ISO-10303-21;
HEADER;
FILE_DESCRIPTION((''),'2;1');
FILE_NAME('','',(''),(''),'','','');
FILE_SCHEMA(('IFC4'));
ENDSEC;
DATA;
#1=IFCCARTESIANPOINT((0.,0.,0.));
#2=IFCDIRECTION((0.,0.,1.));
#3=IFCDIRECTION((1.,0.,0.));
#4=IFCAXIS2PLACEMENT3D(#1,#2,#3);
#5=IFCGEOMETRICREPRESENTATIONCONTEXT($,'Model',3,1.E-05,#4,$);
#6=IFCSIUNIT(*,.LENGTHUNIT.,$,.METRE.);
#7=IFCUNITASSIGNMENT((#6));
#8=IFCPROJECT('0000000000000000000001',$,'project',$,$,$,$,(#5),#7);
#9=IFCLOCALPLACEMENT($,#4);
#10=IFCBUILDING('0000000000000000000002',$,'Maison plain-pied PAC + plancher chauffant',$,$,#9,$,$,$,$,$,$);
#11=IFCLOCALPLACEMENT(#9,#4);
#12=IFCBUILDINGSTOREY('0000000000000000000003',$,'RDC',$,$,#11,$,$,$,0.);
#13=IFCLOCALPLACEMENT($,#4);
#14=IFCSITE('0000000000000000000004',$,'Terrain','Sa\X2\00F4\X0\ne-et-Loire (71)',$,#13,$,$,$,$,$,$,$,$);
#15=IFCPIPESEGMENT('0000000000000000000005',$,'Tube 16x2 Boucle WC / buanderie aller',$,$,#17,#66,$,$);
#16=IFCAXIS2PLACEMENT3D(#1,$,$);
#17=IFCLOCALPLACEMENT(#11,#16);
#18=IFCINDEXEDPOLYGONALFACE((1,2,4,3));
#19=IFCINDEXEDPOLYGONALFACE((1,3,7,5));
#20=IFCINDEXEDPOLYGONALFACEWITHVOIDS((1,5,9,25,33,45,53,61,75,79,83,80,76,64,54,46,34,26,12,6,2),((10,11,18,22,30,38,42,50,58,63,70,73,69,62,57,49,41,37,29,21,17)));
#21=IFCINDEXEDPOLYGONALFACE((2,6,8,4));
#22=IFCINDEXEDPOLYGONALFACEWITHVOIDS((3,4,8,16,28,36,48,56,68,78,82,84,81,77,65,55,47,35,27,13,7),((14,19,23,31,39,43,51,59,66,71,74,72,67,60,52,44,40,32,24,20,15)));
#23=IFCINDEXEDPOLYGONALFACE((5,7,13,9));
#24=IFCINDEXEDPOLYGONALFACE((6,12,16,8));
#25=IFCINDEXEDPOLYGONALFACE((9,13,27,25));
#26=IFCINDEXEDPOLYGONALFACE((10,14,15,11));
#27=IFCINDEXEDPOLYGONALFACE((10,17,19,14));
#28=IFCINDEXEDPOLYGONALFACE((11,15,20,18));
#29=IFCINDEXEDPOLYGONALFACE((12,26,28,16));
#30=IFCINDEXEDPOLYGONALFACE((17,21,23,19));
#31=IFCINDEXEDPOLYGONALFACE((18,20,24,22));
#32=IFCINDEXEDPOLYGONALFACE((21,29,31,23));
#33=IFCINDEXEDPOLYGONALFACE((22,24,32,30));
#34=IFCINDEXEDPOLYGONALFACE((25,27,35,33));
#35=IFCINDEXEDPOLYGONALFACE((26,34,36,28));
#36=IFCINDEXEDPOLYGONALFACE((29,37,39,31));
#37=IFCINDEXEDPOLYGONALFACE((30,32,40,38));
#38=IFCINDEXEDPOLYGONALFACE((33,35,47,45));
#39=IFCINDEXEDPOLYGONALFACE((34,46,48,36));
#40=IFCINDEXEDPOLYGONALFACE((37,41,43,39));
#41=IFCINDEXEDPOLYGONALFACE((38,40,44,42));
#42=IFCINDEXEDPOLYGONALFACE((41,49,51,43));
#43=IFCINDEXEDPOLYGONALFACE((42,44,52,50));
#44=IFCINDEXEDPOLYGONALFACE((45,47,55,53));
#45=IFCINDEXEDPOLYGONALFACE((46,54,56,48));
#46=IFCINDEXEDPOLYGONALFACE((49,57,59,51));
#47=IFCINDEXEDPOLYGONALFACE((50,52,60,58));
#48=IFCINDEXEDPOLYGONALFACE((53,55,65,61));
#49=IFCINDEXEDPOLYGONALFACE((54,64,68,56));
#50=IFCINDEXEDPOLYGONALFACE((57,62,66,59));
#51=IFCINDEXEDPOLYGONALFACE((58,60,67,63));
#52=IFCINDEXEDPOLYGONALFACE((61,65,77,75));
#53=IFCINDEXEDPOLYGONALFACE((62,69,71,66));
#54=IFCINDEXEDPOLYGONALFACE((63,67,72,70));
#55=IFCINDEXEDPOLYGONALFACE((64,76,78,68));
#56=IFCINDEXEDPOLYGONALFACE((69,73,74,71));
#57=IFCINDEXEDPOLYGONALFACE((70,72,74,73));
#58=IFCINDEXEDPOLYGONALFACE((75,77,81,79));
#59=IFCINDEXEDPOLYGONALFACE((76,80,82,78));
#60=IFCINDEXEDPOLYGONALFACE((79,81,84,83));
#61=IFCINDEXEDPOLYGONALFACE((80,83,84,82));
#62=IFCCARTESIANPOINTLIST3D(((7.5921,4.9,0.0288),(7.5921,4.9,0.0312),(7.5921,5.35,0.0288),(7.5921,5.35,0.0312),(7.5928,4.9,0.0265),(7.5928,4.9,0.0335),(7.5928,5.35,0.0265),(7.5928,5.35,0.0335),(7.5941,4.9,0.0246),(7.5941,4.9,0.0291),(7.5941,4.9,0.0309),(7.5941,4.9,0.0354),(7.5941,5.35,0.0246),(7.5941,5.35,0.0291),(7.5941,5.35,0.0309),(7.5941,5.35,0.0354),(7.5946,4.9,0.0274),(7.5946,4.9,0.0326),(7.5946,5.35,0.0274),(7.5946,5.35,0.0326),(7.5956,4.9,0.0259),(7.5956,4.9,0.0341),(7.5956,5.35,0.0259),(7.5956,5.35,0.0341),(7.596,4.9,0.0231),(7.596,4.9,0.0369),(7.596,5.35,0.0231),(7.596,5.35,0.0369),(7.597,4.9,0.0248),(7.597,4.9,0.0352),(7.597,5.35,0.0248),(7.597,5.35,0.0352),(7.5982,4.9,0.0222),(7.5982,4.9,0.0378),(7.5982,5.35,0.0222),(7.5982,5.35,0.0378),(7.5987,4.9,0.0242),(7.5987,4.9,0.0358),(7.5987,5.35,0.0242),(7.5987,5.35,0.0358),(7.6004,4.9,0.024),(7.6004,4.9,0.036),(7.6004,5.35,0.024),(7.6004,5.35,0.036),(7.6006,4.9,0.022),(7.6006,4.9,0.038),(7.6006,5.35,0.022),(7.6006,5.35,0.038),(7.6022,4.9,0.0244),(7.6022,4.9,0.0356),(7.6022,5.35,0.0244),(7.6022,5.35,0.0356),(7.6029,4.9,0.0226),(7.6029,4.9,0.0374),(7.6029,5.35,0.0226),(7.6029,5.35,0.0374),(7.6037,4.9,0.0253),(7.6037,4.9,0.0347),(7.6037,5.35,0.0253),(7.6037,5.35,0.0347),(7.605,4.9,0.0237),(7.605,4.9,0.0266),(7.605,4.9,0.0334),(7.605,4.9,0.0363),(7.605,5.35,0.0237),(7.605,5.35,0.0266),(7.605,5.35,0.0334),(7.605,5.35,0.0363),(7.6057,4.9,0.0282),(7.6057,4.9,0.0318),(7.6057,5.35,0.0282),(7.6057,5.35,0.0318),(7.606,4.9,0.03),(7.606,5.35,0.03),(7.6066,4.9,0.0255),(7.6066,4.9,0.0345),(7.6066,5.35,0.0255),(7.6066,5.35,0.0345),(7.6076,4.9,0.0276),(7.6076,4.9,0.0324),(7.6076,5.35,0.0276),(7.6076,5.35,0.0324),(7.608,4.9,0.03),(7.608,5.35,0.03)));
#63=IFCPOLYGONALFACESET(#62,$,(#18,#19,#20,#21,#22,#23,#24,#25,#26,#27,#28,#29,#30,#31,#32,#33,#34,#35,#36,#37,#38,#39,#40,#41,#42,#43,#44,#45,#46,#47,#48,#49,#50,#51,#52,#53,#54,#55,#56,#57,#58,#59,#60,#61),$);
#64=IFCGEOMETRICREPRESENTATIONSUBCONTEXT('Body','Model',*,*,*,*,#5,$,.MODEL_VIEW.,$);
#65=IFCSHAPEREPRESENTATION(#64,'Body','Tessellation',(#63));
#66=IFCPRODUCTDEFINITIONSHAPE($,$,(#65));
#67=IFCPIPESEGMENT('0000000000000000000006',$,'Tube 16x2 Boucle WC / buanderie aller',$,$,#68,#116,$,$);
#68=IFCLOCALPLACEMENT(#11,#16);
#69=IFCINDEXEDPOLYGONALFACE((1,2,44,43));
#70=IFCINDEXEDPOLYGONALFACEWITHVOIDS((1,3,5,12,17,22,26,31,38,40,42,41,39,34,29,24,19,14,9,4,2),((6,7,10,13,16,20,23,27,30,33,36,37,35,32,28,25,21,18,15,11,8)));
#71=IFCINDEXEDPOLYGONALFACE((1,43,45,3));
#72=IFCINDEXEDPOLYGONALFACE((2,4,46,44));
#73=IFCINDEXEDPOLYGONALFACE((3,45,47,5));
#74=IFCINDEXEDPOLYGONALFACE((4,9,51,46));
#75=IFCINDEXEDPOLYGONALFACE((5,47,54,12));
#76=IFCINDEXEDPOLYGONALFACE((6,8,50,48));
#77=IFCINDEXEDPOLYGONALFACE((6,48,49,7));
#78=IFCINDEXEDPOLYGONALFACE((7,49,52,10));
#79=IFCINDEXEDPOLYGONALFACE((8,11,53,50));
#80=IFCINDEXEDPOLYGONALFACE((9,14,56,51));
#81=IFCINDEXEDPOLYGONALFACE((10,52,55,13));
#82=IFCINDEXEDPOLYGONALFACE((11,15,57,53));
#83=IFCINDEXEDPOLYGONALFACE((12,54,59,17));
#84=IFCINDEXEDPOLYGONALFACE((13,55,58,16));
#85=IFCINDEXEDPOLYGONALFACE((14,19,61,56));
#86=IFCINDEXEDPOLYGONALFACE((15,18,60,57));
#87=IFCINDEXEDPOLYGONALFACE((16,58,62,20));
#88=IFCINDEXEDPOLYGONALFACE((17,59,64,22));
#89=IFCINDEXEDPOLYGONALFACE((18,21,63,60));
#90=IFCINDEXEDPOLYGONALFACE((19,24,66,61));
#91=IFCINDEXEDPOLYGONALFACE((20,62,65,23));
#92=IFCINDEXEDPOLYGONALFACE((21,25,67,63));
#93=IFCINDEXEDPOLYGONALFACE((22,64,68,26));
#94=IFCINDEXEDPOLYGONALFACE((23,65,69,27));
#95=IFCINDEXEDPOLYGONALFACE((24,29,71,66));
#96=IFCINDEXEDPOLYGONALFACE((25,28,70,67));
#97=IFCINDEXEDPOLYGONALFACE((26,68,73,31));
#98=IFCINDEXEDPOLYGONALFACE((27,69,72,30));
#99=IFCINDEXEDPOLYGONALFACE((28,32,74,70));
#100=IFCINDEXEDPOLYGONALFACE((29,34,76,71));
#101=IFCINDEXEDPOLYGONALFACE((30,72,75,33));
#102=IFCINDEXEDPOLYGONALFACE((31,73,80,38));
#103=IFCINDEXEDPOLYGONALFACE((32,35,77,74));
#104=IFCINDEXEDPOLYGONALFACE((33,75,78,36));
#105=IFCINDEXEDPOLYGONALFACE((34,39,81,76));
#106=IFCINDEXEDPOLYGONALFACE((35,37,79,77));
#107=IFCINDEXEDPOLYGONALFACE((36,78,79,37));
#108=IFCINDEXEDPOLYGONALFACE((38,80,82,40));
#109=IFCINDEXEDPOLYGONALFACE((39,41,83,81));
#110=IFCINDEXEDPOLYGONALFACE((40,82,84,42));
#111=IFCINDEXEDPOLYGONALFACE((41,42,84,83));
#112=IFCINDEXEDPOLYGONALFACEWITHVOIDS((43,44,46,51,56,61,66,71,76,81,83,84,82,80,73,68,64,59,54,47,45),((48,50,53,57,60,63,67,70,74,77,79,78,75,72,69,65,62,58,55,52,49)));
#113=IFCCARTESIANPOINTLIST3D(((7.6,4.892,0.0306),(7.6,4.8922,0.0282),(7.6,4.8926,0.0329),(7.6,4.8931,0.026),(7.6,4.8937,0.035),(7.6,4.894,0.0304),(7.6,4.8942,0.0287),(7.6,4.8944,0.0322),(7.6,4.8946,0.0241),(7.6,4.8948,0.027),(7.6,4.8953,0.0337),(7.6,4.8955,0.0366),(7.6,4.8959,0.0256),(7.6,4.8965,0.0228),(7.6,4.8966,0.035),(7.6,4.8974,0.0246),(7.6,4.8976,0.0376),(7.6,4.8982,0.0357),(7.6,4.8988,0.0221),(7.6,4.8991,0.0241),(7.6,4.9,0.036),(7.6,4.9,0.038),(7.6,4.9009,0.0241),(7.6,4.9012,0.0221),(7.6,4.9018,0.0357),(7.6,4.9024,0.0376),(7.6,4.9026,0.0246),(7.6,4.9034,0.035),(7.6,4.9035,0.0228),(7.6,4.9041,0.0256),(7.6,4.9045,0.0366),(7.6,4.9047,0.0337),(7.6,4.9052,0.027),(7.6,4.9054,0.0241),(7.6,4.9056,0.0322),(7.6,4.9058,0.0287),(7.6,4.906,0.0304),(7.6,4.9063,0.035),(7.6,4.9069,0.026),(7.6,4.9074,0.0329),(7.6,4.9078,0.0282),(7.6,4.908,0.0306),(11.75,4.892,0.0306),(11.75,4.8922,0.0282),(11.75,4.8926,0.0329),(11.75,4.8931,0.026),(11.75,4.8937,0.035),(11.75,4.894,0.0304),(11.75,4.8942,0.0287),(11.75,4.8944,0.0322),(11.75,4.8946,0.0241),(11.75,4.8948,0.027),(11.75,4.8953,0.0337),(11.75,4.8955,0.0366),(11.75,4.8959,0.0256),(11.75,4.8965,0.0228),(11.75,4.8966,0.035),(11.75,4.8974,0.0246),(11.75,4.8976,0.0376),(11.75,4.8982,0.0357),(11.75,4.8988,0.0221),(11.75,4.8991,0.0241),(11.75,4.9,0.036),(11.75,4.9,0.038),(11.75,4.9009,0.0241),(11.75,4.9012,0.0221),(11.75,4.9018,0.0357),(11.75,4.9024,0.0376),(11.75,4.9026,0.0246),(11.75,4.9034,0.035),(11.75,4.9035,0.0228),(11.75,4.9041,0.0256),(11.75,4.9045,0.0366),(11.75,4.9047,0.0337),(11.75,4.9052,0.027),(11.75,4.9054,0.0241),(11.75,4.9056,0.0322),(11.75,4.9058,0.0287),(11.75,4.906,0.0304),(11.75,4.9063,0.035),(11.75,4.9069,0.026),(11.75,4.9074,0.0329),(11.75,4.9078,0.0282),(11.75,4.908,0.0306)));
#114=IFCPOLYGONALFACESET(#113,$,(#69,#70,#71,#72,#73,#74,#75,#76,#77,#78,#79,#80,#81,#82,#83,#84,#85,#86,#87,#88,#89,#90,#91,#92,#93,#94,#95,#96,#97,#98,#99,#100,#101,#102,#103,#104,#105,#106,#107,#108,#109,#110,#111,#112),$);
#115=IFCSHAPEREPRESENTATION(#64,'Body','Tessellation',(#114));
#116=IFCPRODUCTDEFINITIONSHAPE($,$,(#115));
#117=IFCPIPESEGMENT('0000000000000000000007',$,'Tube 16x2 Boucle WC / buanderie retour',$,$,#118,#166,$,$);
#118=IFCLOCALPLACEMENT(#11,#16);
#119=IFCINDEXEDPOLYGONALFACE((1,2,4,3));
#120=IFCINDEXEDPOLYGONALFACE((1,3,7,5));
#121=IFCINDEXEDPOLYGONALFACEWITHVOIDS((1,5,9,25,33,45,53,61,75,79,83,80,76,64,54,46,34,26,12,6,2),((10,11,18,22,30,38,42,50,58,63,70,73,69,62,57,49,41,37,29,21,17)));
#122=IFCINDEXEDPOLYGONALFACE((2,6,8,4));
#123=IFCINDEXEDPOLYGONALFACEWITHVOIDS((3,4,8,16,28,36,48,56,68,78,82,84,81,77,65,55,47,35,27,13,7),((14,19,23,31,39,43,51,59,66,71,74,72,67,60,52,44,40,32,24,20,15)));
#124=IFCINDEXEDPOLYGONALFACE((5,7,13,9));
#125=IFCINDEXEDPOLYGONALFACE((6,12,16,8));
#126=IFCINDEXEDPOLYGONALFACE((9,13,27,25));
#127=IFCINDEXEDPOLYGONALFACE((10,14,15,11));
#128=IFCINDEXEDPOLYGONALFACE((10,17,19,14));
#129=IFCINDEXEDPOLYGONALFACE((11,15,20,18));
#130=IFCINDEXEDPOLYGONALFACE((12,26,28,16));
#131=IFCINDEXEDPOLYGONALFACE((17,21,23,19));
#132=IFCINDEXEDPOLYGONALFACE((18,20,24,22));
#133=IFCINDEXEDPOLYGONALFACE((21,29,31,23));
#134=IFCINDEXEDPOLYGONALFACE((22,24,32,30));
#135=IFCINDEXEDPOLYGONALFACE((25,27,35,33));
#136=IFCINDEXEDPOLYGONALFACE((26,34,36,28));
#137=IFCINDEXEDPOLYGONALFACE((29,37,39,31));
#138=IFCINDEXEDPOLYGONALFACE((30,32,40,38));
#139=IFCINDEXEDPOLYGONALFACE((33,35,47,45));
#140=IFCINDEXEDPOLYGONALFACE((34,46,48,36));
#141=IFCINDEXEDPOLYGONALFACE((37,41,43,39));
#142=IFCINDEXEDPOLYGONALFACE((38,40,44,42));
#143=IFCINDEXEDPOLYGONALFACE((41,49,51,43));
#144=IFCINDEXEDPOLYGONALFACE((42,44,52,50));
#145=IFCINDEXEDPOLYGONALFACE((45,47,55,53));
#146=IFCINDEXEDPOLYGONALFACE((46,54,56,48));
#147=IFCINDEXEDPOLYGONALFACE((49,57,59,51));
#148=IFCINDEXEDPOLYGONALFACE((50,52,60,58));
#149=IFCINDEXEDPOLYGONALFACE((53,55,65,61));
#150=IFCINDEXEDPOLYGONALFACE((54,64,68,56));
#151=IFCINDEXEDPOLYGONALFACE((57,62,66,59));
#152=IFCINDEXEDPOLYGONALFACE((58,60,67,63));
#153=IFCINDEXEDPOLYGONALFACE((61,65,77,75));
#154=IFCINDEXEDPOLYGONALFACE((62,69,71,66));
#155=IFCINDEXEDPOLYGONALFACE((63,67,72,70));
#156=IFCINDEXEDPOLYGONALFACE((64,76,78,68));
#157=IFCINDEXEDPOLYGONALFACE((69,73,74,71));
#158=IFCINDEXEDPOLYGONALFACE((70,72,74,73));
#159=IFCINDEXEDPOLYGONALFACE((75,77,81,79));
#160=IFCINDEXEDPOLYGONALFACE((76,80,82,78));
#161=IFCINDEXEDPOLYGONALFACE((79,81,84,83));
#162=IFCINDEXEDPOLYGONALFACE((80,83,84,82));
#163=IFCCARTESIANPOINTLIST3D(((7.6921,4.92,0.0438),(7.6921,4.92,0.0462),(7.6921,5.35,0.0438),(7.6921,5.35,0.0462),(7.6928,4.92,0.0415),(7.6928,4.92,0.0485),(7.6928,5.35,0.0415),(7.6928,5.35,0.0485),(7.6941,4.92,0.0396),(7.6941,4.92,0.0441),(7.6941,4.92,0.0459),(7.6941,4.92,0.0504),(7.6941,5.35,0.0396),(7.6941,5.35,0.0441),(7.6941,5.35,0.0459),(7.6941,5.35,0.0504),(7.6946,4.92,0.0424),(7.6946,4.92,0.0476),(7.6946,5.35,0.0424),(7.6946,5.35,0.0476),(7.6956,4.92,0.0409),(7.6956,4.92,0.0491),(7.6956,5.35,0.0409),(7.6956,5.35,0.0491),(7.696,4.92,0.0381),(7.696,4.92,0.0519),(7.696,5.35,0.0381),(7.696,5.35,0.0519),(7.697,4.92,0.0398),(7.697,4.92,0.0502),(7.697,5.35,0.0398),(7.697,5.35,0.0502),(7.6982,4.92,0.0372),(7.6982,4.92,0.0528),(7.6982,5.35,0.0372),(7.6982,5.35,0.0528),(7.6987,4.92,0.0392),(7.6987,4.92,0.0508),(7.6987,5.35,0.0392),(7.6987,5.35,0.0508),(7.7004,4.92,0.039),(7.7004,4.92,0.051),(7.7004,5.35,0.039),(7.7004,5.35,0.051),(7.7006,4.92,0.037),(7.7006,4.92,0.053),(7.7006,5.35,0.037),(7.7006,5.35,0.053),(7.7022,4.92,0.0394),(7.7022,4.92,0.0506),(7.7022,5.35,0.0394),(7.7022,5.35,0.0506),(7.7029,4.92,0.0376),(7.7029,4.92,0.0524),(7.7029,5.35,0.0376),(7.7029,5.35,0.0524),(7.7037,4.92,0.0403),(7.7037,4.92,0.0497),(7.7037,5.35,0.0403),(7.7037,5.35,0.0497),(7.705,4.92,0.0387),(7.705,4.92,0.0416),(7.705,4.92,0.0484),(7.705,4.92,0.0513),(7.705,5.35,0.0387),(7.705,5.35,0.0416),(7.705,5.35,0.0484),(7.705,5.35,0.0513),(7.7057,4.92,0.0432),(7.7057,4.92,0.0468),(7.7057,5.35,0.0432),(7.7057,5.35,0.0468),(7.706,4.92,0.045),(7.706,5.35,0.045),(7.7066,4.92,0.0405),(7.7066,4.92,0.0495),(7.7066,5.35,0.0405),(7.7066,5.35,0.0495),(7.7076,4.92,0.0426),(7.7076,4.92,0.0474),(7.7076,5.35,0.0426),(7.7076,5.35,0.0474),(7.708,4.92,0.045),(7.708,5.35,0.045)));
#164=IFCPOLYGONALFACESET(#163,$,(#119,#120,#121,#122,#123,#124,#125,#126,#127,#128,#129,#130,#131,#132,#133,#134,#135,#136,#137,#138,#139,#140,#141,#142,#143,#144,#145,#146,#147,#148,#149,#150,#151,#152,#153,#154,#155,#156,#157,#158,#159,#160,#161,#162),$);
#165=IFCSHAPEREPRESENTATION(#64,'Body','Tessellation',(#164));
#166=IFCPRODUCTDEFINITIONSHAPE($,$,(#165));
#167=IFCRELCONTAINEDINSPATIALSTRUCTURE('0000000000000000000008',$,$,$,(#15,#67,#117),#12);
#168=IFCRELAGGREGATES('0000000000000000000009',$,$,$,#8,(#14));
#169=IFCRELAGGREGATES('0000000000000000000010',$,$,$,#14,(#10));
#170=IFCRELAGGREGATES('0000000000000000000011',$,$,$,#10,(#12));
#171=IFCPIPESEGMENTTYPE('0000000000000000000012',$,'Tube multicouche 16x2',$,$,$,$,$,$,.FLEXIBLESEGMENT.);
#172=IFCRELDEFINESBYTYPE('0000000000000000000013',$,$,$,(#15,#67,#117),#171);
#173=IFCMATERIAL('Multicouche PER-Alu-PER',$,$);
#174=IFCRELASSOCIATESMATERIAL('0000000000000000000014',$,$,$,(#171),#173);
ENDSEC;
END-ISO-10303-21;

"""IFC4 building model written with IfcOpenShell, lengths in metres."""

from ifc_helpers import new_model, si_unit, frame, origin_with_axes, place, context, subcontext, project, spatial, hollow_circle, extrude, material, type_object, element, save


model = new_model("IFC4")

# Units and contexts
model_context = context("Model", 3, precision=1e-05, world=origin_with_axes())
body_context = subcontext(model_context, "Body", "Model", "MODEL_VIEW")
ifc_project = project(units=[si_unit("LENGTHUNIT", "METRE")], contexts=[model_context])

# Site, building, storey
site_placement = place(None, origin_with_axes())
site = spatial("IfcSite", under=ifc_project, at=site_placement, Name="Terrain", Description="Saône-et-Loire (71)")
building_placement = place(None, origin_with_axes())
building = spatial("IfcBuilding", under=site, at=building_placement, Name="Maison plain-pied PAC + plancher chauffant")
storey_placement = place(building_placement, origin_with_axes())
storey = spatial("IfcBuildingStorey", under=building, at=storey_placement, Name="RDC", Elevation=0.0)

# Pipe segments
ifc_material_1 = material(Name="Multicouche PER-Alu-PER")
pipe_segment_type_1 = type_object("IfcPipeSegmentType", Name="Tube multicouche 16x2", PredefinedType="FLEXIBLESEGMENT", material=ifc_material_1)
pipe_segment_1_placement = place(storey_placement, frame((7.6, 5.35, 0.03), z_axis=(0.0, -1.0, 0.0), x_axis=(1.0, 0.0, 0.0)))
element("IfcPipeSegment", 1, at=pipe_segment_1_placement, inside=storey, type_object=pipe_segment_type_1, Name="Tube 16x2 Boucle WC / buanderie aller", context=body_context, shape_type="SweptSolid", body=[
    extrude(hollow_circle(Radius=0.008, WallThickness=0.002), origin_with_axes(), (0.0, 0.0, 1.0), 0.45),
])
pipe_segment_2_placement = place(storey_placement, frame((7.6, 4.9, 0.03), z_axis=(1.0, 0.0, 0.0), x_axis=(0.0, 0.0, 1.0)))
element("IfcPipeSegment", 2, at=pipe_segment_2_placement, inside=storey, type_object=pipe_segment_type_1, Name="Tube 16x2 Boucle WC / buanderie aller", context=body_context, shape_type="SweptSolid", body=[
    extrude(hollow_circle(Radius=0.008, WallThickness=0.002), origin_with_axes(), (0.0, 0.0, 1.0), 4.15),
])
pipe_segment_3_placement = place(storey_placement, frame((7.7, 4.92, 0.045), z_axis=(0.0, 1.0, 0.0), x_axis=(1.0, 0.0, 0.0)))
element("IfcPipeSegment", 3, at=pipe_segment_3_placement, inside=storey, type_object=pipe_segment_type_1, Name="Tube 16x2 Boucle WC / buanderie retour", context=body_context, shape_type="SweptSolid", body=[
    extrude(hollow_circle(Radius=0.008, WallThickness=0.002), origin_with_axes(), (0.0, 0.0, 1.0), 0.43),
])

save(model, "model.ifc")
